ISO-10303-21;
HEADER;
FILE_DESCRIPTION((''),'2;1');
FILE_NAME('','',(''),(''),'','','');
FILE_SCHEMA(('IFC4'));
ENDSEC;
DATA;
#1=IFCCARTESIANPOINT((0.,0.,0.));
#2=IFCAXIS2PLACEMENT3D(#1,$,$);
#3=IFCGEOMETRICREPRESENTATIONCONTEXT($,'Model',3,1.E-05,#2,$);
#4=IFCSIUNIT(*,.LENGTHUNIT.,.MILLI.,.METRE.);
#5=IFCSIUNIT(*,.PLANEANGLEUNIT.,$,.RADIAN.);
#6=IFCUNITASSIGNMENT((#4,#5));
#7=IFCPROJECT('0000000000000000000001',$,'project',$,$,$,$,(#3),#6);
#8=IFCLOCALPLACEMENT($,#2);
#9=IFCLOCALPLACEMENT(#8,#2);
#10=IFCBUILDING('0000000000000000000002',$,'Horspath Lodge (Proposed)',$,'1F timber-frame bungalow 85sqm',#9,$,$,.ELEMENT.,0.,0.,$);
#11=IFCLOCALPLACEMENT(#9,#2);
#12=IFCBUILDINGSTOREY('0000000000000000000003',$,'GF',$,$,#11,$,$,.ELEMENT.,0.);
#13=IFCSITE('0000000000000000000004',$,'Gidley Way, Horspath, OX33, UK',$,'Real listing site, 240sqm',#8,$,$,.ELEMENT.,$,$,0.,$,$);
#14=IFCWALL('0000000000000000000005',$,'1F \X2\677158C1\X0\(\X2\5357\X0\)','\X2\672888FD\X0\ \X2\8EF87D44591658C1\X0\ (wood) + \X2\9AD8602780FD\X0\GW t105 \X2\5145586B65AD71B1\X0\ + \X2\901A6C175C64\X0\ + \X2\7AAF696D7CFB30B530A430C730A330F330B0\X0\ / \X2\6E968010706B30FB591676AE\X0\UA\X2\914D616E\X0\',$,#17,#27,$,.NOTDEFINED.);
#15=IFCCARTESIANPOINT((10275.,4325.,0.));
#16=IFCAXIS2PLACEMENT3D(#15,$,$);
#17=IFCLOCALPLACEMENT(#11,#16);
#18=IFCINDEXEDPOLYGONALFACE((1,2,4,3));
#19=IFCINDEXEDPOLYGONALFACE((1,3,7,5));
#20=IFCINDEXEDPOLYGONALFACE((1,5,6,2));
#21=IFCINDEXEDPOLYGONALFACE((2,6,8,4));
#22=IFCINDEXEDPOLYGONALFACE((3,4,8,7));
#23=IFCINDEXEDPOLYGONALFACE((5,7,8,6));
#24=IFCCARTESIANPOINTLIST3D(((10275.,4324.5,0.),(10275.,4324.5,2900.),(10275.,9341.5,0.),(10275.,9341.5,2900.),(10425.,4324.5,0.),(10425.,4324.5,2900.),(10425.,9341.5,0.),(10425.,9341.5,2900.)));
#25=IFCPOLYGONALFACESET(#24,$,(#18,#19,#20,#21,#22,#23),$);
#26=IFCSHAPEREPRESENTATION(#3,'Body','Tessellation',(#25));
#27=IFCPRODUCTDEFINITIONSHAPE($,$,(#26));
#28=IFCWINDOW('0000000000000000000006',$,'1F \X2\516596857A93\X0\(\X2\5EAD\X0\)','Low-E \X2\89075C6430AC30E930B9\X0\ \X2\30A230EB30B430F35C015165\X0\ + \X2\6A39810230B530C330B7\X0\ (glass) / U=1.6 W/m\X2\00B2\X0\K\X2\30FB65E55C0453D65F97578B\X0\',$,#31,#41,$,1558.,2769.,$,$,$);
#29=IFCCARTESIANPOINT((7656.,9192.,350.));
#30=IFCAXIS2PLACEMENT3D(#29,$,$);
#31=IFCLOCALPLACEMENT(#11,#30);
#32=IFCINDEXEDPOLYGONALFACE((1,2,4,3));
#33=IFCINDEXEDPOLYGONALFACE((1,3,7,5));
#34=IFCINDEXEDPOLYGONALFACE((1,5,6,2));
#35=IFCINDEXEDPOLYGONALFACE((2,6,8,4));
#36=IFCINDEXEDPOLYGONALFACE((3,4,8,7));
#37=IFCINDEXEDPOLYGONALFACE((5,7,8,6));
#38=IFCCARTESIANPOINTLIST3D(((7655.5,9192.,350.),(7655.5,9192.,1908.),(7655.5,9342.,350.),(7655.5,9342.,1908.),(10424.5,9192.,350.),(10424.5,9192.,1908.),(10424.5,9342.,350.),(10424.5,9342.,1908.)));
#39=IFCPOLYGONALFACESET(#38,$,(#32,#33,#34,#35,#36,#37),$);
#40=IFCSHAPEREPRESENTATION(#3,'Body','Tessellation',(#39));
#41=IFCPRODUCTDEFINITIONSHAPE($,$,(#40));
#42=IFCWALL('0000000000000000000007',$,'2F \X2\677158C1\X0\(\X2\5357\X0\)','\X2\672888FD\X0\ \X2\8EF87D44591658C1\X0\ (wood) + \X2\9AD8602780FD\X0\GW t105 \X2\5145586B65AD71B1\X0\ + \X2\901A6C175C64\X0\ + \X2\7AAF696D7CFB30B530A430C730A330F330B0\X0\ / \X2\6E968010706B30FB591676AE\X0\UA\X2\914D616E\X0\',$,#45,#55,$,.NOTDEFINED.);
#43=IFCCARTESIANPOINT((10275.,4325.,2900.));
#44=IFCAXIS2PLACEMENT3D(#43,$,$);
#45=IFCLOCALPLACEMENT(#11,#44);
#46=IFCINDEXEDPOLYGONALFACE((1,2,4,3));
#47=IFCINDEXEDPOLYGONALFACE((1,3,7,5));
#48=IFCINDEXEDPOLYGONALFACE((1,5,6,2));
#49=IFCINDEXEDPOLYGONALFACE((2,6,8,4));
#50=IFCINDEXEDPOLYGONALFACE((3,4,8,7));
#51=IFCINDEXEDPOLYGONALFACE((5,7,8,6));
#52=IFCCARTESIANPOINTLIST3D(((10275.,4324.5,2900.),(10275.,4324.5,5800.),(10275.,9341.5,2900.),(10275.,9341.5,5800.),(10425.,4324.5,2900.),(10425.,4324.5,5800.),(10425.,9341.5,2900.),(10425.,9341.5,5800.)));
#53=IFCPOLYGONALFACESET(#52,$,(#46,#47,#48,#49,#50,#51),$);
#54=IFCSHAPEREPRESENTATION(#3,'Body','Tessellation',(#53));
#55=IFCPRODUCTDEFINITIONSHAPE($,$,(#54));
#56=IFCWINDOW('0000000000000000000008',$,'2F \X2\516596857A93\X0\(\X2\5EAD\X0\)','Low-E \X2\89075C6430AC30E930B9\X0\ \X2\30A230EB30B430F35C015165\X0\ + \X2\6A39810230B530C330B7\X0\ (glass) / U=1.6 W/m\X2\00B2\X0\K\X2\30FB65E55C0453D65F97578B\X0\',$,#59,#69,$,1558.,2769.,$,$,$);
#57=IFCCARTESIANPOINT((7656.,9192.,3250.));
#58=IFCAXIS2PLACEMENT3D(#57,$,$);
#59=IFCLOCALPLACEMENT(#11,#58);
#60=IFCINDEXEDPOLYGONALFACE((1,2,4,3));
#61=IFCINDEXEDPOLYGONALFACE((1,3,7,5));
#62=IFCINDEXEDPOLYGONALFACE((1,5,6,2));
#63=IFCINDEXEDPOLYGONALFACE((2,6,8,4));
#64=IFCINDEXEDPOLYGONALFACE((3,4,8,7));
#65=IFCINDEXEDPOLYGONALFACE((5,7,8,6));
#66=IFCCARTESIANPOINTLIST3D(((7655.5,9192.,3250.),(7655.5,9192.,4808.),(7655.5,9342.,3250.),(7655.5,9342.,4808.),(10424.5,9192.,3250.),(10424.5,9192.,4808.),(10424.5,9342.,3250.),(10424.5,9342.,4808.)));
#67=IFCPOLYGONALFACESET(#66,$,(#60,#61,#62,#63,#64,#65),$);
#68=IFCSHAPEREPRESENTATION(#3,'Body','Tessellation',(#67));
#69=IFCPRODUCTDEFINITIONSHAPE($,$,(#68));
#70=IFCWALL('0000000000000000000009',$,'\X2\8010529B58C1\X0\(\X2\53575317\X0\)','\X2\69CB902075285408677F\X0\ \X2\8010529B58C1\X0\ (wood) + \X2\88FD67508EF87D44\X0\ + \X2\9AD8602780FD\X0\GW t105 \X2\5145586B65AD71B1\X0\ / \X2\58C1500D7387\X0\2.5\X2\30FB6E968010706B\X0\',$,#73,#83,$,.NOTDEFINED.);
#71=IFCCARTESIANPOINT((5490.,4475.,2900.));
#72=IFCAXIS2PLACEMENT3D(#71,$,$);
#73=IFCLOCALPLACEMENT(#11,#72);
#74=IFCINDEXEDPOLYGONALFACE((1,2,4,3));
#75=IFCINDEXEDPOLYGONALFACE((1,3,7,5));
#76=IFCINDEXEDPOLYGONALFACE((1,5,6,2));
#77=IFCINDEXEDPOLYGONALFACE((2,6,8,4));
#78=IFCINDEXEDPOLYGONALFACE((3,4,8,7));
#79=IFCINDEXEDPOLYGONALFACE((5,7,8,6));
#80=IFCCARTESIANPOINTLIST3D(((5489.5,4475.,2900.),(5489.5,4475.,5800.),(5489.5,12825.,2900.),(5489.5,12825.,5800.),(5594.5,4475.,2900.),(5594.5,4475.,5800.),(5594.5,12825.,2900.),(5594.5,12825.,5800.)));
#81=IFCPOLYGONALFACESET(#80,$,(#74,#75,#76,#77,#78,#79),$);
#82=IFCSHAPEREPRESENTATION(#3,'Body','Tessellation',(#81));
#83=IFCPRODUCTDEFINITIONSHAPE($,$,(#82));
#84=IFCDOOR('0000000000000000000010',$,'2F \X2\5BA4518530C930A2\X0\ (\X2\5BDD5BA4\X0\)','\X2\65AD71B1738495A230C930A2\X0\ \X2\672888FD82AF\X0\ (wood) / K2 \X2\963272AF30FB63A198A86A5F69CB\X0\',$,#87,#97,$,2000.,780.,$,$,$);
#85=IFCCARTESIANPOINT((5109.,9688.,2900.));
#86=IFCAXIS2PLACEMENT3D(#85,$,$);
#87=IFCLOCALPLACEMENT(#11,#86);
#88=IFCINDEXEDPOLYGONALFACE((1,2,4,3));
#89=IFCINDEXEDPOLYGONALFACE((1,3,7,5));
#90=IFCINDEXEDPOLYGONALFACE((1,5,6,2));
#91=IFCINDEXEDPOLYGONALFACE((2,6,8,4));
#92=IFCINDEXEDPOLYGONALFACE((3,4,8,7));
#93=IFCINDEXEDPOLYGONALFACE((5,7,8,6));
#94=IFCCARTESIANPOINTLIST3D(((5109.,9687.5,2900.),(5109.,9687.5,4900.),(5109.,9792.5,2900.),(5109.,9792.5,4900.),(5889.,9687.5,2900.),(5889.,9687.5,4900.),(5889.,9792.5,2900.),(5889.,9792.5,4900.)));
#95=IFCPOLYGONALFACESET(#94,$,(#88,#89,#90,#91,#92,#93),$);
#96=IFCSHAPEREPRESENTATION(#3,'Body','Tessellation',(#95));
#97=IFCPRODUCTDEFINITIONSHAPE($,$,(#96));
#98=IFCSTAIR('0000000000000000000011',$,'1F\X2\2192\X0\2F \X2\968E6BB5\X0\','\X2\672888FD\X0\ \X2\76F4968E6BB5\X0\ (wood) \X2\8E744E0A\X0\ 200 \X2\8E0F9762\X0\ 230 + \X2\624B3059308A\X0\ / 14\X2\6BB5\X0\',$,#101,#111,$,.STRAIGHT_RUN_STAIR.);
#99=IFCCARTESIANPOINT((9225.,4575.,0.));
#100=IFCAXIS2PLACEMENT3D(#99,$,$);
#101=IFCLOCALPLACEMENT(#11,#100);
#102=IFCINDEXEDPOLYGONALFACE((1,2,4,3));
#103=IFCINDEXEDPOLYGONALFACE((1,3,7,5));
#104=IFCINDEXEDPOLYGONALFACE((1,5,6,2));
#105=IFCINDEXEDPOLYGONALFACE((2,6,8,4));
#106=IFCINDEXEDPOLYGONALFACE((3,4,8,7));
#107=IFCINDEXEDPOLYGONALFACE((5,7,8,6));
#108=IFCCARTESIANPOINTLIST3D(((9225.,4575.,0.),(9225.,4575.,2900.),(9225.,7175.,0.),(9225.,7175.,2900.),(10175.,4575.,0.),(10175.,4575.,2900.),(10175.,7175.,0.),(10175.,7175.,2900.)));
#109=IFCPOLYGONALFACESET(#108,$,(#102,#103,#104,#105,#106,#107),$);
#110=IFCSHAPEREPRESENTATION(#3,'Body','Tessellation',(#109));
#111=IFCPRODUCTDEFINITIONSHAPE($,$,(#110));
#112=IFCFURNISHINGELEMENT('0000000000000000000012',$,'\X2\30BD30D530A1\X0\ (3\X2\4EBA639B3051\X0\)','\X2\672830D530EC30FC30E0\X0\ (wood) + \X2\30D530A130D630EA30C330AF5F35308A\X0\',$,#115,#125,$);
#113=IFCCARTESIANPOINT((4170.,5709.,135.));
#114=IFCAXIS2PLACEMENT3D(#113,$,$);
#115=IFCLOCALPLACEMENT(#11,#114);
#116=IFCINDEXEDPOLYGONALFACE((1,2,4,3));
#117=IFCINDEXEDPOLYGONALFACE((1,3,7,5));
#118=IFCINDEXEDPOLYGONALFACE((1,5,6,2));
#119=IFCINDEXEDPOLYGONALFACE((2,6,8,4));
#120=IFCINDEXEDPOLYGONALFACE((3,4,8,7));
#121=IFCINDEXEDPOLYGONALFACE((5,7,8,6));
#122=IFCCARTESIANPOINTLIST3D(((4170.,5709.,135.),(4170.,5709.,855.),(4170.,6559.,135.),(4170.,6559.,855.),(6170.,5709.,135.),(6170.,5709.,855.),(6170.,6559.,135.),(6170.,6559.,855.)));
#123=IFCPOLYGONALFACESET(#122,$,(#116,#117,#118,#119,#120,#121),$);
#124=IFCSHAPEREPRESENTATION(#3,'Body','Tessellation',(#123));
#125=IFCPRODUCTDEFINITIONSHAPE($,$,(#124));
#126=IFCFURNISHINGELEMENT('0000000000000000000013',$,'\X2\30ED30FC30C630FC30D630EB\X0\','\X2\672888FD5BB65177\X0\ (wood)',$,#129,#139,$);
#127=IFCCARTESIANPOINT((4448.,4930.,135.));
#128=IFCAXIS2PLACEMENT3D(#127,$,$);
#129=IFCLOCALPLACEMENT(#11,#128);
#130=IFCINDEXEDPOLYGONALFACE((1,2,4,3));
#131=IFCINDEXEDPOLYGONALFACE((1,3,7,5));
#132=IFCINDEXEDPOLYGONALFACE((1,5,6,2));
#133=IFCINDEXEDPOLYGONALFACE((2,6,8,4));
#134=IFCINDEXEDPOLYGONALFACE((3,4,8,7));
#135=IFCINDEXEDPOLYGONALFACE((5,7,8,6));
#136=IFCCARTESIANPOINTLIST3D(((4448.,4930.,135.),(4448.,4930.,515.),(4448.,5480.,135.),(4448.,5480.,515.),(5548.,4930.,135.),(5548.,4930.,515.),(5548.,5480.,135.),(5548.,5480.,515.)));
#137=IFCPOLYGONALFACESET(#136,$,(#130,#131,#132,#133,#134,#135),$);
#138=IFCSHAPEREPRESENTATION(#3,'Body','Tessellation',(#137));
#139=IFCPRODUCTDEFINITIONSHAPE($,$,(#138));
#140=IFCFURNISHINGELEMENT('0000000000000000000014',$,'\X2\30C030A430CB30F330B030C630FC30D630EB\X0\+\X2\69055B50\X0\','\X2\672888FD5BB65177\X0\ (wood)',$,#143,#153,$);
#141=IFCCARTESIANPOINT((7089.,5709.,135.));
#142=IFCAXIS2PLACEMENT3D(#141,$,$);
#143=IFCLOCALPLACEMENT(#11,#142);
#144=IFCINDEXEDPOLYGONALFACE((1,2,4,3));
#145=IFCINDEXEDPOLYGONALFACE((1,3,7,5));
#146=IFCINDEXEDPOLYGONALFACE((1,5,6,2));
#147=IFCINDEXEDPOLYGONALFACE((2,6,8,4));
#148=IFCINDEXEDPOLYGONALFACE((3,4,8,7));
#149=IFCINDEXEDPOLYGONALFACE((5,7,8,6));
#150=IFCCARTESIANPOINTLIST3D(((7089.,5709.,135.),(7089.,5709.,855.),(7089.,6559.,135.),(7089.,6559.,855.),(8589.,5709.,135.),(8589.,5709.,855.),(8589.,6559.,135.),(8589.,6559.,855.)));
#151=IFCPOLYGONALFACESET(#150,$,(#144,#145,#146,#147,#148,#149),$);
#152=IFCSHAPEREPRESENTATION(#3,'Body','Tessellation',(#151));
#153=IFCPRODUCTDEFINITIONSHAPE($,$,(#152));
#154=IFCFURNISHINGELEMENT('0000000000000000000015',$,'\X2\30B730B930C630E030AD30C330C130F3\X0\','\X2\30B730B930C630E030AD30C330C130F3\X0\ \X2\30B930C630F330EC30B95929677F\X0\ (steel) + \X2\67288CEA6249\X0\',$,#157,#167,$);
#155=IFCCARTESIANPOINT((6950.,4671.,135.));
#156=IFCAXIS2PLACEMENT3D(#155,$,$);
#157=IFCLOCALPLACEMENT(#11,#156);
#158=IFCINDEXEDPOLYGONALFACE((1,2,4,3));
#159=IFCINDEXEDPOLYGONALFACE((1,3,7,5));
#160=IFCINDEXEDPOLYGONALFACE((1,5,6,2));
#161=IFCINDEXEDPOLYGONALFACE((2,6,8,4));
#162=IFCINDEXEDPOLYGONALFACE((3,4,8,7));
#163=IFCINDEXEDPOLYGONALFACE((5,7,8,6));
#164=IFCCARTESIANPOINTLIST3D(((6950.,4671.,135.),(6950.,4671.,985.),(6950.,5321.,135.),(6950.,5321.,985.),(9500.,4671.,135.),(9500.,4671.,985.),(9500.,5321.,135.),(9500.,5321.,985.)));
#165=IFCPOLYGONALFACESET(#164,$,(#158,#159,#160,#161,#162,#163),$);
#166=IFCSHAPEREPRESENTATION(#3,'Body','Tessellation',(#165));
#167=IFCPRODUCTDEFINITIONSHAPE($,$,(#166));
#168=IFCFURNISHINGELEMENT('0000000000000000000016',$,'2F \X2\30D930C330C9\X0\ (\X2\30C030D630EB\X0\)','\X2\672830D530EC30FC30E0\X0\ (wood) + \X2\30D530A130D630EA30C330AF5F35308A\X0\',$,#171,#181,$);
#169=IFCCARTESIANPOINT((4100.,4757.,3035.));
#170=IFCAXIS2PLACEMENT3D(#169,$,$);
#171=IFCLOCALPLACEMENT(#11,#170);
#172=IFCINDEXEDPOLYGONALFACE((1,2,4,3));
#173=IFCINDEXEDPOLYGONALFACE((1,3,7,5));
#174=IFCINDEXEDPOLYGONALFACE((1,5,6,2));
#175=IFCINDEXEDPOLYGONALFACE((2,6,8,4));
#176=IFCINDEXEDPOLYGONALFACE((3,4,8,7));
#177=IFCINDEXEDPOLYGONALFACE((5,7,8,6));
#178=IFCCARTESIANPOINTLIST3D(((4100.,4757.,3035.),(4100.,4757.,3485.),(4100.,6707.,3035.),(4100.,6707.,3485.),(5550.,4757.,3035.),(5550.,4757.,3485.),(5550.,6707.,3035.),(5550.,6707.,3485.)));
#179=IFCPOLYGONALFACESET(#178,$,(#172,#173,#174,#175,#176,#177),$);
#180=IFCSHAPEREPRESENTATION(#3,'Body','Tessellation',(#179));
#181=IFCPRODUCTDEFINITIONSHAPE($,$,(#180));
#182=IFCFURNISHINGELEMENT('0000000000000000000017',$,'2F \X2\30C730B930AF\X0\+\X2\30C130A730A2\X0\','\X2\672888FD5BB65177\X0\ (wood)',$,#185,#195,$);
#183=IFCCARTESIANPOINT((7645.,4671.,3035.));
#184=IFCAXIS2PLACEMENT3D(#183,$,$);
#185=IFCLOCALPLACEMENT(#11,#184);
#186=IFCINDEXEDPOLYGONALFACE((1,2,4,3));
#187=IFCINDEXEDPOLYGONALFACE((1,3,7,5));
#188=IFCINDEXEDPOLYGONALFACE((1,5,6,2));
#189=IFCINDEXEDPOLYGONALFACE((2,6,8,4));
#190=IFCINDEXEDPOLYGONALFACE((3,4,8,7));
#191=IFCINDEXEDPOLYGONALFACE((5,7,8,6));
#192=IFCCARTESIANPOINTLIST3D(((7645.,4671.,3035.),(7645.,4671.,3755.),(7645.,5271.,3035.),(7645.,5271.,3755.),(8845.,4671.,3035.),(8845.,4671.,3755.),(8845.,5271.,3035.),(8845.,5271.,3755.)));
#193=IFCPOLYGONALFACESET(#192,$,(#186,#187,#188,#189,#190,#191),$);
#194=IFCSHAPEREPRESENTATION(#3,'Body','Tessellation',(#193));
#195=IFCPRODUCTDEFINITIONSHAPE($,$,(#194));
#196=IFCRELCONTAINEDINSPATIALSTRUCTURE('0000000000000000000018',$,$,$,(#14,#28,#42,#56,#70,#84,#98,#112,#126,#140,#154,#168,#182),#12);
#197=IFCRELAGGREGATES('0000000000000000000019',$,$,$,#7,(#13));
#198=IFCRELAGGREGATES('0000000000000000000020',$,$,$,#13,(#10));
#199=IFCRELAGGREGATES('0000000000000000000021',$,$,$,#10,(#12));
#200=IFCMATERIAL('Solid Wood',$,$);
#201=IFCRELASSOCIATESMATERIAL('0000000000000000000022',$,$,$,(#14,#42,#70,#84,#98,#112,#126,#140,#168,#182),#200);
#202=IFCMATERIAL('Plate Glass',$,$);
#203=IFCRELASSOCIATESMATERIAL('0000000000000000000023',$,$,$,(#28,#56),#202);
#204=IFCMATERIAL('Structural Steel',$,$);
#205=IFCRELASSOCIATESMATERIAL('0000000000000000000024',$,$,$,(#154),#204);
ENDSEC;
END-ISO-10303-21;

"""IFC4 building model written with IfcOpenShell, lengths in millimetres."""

from ifc_helpers import new_model, si_unit, frame, frame_2d, origin, place, context, project, spatial, rectangle, extrude, material, element, fill, save


model = new_model("IFC4")

# Units and contexts
model_context = context("Model", 3, precision=1e-05, world=origin())
ifc_project = project(units=[si_unit("LENGTHUNIT", "METRE", prefix="MILLI"), si_unit("PLANEANGLEUNIT", "RADIAN")], contexts=[model_context])

# Site, building, storey
site_placement = place(None, origin())
site = spatial("IfcSite", under=ifc_project, at=site_placement, Name="Gidley Way, Horspath, OX33, UK", ObjectType="Real listing site, 240sqm", CompositionType="ELEMENT", RefElevation=0.0)
building_placement = place(site_placement, origin())
building = spatial("IfcBuilding", under=site, at=building_placement, Name="Horspath Lodge (Proposed)", ObjectType="1F timber-frame bungalow 85sqm", CompositionType="ELEMENT", ElevationOfRefHeight=0.0, ElevationOfTerrain=0.0)
storey_placement = place(building_placement, origin())
storey = spatial("IfcBuildingStorey", under=building, at=storey_placement, Name="GF", CompositionType="ELEMENT", Elevation=0.0)

# Wall, opening, window
ifc_material_1 = material(Name="Solid Wood")
wall_1_placement = place(storey_placement, frame((10275.0, 4325.0, 0.0)))
wall_1 = element("IfcWall", 1, at=wall_1_placement, inside=storey, material=ifc_material_1, Name="1F 東壁(南)", Description="木製 軸組外壁 (wood) + 高性能GW t105 充填断熱 + 通気層 + 窯業系サイディング / 準耐火・外皮UA配慮", PredefinedType="NOTDEFINED", context=model_context, shape_type="SweptSolid", body=[
    extrude(rectangle(XDim=150.0, YDim=5017.0, at=frame_2d((75.0, 2508.0))), frame((10275.0, 4325.0, 0.0)), (0.0, 0.0, 1.0), 2900.0),
])
opening_1_placement = place(storey_placement, frame((7656.0, 9192.0, 350.0)))
opening_1 = element("IfcOpeningElement", 2, at=opening_1_placement, cuts=wall_1, PredefinedType="NOTDEFINED", context=model_context, shape_type="SweptSolid", body=[
    extrude(rectangle(XDim=2769.0, YDim=150.0, at=frame_2d((1384.0, 75.0))), frame((7656.0, 9192.0, 350.0)), (0.0, 0.0, 1.0), 1558.0),
])
ifc_material_2 = material(Name="Plate Glass")
window_1_placement = place(storey_placement, frame((7656.0, 9192.0, 350.0)))
window_1 = element("IfcWindow", 3, at=window_1_placement, inside=storey, material=ifc_material_2, Name="1F 入隅窓(庭)", Description="Low-E 複層ガラス アルゴン封入 + 樹脂サッシ (glass) / U=1.6 W/m²K・日射取得型", OverallHeight=1558.0, OverallWidth=2769.0, context=model_context, shape_type="SweptSolid", body=[
    extrude(rectangle(XDim=2769.0, YDim=150.0, at=frame_2d((1384.0, 75.0))), frame((7656.0, 9192.0, 350.0)), (0.0, 0.0, 1.0), 1558.0),
])
fill(opening_1, window_1)

# Wall, opening, window
wall_2_placement = place(storey_placement, frame((10275.0, 4325.0, 2900.0)))
wall_2 = element("IfcWall", 4, at=wall_2_placement, inside=storey, material=ifc_material_1, Name="2F 東壁(南)", Description="木製 軸組外壁 (wood) + 高性能GW t105 充填断熱 + 通気層 + 窯業系サイディング / 準耐火・外皮UA配慮", PredefinedType="NOTDEFINED", context=model_context, shape_type="SweptSolid", body=[
    extrude(rectangle(XDim=150.0, YDim=5017.0, at=frame_2d((75.0, 2508.0))), frame((10275.0, 4325.0, 2900.0)), (0.0, 0.0, 1.0), 2900.0),
])
opening_2_placement = place(storey_placement, frame((7656.0, 9192.0, 3250.0)))
opening_2 = element("IfcOpeningElement", 5, at=opening_2_placement, cuts=wall_2, PredefinedType="NOTDEFINED", context=model_context, shape_type="SweptSolid", body=[
    extrude(rectangle(XDim=2769.0, YDim=150.0, at=frame_2d((1384.0, 75.0))), frame((7656.0, 9192.0, 3250.0)), (0.0, 0.0, 1.0), 1558.0),
])
window_2_placement = place(storey_placement, frame((7656.0, 9192.0, 3250.0)))
window_2 = element("IfcWindow", 6, at=window_2_placement, inside=storey, material=ifc_material_2, Name="2F 入隅窓(庭)", Description="Low-E 複層ガラス アルゴン封入 + 樹脂サッシ (glass) / U=1.6 W/m²K・日射取得型", OverallHeight=1558.0, OverallWidth=2769.0, context=model_context, shape_type="SweptSolid", body=[
    extrude(rectangle(XDim=2769.0, YDim=150.0, at=frame_2d((1384.0, 75.0))), frame((7656.0, 9192.0, 3250.0)), (0.0, 0.0, 1.0), 1558.0),
])
fill(opening_2, window_2)

# Wall, opening, door
wall_3_placement = place(storey_placement, frame((5490.0, 4475.0, 2900.0)))
wall_3 = element("IfcWall", 7, at=wall_3_placement, inside=storey, material=ifc_material_1, Name="耐力壁(南北)", Description="構造用合板 耐力壁 (wood) + 製材軸組 + 高性能GW t105 充填断熱 / 壁倍率2.5・準耐火", PredefinedType="NOTDEFINED", context=model_context, shape_type="SweptSolid", body=[
    extrude(rectangle(XDim=105.0, YDim=8350.0, at=frame_2d((52.0, 4175.0))), frame((5490.0, 4475.0, 2900.0)), (0.0, 0.0, 1.0), 2900.0),
])
opening_3_placement = place(storey_placement, frame((5109.0, 9688.0, 2900.0)))
opening_3 = element("IfcOpeningElement", 8, at=opening_3_placement, cuts=wall_3, PredefinedType="NOTDEFINED", context=model_context, shape_type="SweptSolid", body=[
    extrude(rectangle(XDim=780.0, YDim=105.0, at=frame_2d((390.0, 52.0))), frame((5109.0, 9688.0, 2900.0)), (0.0, 0.0, 1.0), 2000.0),
])
door_1_placement = place(storey_placement, frame((5109.0, 9688.0, 2900.0)))
door_1 = element("IfcDoor", 9, at=door_1_placement, inside=storey, material=ifc_material_1, Name="2F 室内ドア (寝室)", Description="断熱玄関ドア 木製芯 (wood) / K2 防犯・採風機構", OverallHeight=2000.0, OverallWidth=780.0, context=model_context, shape_type="SweptSolid", body=[
    extrude(rectangle(XDim=780.0, YDim=105.0, at=frame_2d((390.0, 52.0))), frame((5109.0, 9688.0, 2900.0)), (0.0, 0.0, 1.0), 2000.0),
])
fill(opening_3, door_1)

# Stair
stair_placement = place(storey_placement, frame((9225.0, 4575.0, 0.0)))
element("IfcStair", 10, at=stair_placement, inside=storey, material=ifc_material_1, Name="1F→2F 階段", Description="木製 直階段 (wood) 蹴上 200 踏面 230 + 手すり / 14段", PredefinedType="STRAIGHT_RUN_STAIR", context=model_context, shape_type="SweptSolid", body=[
    extrude(rectangle(XDim=950.0, YDim=2600.0, at=frame_2d((475.0, 1300.0))), frame((9225.0, 4575.0, 0.0)), (0.0, 0.0, 1.0), 2900.0),
])

# Furnishing elements
furnishing_1_placement = place(storey_placement, frame((4170.0, 5709.0, 135.0)))
element("IfcFurnishingElement", 11, at=furnishing_1_placement, inside=storey, material=ifc_material_1, Name="ソファ (3人掛け)", Description="木フレーム (wood) + ファブリック張り", context=model_context, shape_type="SweptSolid", body=[
    extrude(rectangle(XDim=2000.0, YDim=850.0, at=frame_2d((1000.0, 425.0))), frame((4170.0, 5709.0, 135.0)), (0.0, 0.0, 1.0), 720.0),
])
furnishing_2_placement = place(storey_placement, frame((4448.0, 4930.0, 135.0)))
element("IfcFurnishingElement", 12, at=furnishing_2_placement, inside=storey, material=ifc_material_1, Name="ローテーブル", Description="木製家具 (wood)", context=model_context, shape_type="SweptSolid", body=[
    extrude(rectangle(XDim=1100.0, YDim=550.0, at=frame_2d((550.0, 275.0))), frame((4448.0, 4930.0, 135.0)), (0.0, 0.0, 1.0), 380.0),
])
furnishing_3_placement = place(storey_placement, frame((7089.0, 5709.0, 135.0)))
element("IfcFurnishingElement", 13, at=furnishing_3_placement, inside=storey, material=ifc_material_1, Name="ダイニングテーブル+椅子", Description="木製家具 (wood)", context=model_context, shape_type="SweptSolid", body=[
    extrude(rectangle(XDim=1500.0, YDim=850.0, at=frame_2d((750.0, 425.0))), frame((7089.0, 5709.0, 135.0)), (0.0, 0.0, 1.0), 720.0),
])
ifc_material_3 = material(Name="Structural Steel")
furnishing_4_placement = place(storey_placement, frame((6950.0, 4671.0, 135.0)))
element("IfcFurnishingElement", 14, at=furnishing_4_placement, inside=storey, material=ifc_material_3, Name="システムキッチン", Description="システムキッチン ステンレス天板 (steel) + 木質扉", context=model_context, shape_type="SweptSolid", body=[
    extrude(rectangle(XDim=2550.0, YDim=650.0, at=frame_2d((1275.0, 325.0))), frame((6950.0, 4671.0, 135.0)), (0.0, 0.0, 1.0), 850.0),
])
furnishing_5_placement = place(storey_placement, frame((4100.0, 4757.0, 3035.0)))
element("IfcFurnishingElement", 15, at=furnishing_5_placement, inside=storey, material=ifc_material_1, Name="2F ベッド (ダブル)", Description="木フレーム (wood) + ファブリック張り", context=model_context, shape_type="SweptSolid", body=[
    extrude(rectangle(XDim=1450.0, YDim=1950.0, at=frame_2d((725.0, 975.0))), frame((4100.0, 4757.0, 3035.0)), (0.0, 0.0, 1.0), 450.0),
])
furnishing_6_placement = place(storey_placement, frame((7645.0, 4671.0, 3035.0)))
element("IfcFurnishingElement", 16, at=furnishing_6_placement, inside=storey, material=ifc_material_1, Name="2F デスク+チェア", Description="木製家具 (wood)", context=model_context, shape_type="SweptSolid", body=[
    extrude(rectangle(XDim=1200.0, YDim=600.0, at=frame_2d((600.0, 300.0))), frame((7645.0, 4671.0, 3035.0)), (0.0, 0.0, 1.0), 720.0),
])

save(model, "model.ifc")
